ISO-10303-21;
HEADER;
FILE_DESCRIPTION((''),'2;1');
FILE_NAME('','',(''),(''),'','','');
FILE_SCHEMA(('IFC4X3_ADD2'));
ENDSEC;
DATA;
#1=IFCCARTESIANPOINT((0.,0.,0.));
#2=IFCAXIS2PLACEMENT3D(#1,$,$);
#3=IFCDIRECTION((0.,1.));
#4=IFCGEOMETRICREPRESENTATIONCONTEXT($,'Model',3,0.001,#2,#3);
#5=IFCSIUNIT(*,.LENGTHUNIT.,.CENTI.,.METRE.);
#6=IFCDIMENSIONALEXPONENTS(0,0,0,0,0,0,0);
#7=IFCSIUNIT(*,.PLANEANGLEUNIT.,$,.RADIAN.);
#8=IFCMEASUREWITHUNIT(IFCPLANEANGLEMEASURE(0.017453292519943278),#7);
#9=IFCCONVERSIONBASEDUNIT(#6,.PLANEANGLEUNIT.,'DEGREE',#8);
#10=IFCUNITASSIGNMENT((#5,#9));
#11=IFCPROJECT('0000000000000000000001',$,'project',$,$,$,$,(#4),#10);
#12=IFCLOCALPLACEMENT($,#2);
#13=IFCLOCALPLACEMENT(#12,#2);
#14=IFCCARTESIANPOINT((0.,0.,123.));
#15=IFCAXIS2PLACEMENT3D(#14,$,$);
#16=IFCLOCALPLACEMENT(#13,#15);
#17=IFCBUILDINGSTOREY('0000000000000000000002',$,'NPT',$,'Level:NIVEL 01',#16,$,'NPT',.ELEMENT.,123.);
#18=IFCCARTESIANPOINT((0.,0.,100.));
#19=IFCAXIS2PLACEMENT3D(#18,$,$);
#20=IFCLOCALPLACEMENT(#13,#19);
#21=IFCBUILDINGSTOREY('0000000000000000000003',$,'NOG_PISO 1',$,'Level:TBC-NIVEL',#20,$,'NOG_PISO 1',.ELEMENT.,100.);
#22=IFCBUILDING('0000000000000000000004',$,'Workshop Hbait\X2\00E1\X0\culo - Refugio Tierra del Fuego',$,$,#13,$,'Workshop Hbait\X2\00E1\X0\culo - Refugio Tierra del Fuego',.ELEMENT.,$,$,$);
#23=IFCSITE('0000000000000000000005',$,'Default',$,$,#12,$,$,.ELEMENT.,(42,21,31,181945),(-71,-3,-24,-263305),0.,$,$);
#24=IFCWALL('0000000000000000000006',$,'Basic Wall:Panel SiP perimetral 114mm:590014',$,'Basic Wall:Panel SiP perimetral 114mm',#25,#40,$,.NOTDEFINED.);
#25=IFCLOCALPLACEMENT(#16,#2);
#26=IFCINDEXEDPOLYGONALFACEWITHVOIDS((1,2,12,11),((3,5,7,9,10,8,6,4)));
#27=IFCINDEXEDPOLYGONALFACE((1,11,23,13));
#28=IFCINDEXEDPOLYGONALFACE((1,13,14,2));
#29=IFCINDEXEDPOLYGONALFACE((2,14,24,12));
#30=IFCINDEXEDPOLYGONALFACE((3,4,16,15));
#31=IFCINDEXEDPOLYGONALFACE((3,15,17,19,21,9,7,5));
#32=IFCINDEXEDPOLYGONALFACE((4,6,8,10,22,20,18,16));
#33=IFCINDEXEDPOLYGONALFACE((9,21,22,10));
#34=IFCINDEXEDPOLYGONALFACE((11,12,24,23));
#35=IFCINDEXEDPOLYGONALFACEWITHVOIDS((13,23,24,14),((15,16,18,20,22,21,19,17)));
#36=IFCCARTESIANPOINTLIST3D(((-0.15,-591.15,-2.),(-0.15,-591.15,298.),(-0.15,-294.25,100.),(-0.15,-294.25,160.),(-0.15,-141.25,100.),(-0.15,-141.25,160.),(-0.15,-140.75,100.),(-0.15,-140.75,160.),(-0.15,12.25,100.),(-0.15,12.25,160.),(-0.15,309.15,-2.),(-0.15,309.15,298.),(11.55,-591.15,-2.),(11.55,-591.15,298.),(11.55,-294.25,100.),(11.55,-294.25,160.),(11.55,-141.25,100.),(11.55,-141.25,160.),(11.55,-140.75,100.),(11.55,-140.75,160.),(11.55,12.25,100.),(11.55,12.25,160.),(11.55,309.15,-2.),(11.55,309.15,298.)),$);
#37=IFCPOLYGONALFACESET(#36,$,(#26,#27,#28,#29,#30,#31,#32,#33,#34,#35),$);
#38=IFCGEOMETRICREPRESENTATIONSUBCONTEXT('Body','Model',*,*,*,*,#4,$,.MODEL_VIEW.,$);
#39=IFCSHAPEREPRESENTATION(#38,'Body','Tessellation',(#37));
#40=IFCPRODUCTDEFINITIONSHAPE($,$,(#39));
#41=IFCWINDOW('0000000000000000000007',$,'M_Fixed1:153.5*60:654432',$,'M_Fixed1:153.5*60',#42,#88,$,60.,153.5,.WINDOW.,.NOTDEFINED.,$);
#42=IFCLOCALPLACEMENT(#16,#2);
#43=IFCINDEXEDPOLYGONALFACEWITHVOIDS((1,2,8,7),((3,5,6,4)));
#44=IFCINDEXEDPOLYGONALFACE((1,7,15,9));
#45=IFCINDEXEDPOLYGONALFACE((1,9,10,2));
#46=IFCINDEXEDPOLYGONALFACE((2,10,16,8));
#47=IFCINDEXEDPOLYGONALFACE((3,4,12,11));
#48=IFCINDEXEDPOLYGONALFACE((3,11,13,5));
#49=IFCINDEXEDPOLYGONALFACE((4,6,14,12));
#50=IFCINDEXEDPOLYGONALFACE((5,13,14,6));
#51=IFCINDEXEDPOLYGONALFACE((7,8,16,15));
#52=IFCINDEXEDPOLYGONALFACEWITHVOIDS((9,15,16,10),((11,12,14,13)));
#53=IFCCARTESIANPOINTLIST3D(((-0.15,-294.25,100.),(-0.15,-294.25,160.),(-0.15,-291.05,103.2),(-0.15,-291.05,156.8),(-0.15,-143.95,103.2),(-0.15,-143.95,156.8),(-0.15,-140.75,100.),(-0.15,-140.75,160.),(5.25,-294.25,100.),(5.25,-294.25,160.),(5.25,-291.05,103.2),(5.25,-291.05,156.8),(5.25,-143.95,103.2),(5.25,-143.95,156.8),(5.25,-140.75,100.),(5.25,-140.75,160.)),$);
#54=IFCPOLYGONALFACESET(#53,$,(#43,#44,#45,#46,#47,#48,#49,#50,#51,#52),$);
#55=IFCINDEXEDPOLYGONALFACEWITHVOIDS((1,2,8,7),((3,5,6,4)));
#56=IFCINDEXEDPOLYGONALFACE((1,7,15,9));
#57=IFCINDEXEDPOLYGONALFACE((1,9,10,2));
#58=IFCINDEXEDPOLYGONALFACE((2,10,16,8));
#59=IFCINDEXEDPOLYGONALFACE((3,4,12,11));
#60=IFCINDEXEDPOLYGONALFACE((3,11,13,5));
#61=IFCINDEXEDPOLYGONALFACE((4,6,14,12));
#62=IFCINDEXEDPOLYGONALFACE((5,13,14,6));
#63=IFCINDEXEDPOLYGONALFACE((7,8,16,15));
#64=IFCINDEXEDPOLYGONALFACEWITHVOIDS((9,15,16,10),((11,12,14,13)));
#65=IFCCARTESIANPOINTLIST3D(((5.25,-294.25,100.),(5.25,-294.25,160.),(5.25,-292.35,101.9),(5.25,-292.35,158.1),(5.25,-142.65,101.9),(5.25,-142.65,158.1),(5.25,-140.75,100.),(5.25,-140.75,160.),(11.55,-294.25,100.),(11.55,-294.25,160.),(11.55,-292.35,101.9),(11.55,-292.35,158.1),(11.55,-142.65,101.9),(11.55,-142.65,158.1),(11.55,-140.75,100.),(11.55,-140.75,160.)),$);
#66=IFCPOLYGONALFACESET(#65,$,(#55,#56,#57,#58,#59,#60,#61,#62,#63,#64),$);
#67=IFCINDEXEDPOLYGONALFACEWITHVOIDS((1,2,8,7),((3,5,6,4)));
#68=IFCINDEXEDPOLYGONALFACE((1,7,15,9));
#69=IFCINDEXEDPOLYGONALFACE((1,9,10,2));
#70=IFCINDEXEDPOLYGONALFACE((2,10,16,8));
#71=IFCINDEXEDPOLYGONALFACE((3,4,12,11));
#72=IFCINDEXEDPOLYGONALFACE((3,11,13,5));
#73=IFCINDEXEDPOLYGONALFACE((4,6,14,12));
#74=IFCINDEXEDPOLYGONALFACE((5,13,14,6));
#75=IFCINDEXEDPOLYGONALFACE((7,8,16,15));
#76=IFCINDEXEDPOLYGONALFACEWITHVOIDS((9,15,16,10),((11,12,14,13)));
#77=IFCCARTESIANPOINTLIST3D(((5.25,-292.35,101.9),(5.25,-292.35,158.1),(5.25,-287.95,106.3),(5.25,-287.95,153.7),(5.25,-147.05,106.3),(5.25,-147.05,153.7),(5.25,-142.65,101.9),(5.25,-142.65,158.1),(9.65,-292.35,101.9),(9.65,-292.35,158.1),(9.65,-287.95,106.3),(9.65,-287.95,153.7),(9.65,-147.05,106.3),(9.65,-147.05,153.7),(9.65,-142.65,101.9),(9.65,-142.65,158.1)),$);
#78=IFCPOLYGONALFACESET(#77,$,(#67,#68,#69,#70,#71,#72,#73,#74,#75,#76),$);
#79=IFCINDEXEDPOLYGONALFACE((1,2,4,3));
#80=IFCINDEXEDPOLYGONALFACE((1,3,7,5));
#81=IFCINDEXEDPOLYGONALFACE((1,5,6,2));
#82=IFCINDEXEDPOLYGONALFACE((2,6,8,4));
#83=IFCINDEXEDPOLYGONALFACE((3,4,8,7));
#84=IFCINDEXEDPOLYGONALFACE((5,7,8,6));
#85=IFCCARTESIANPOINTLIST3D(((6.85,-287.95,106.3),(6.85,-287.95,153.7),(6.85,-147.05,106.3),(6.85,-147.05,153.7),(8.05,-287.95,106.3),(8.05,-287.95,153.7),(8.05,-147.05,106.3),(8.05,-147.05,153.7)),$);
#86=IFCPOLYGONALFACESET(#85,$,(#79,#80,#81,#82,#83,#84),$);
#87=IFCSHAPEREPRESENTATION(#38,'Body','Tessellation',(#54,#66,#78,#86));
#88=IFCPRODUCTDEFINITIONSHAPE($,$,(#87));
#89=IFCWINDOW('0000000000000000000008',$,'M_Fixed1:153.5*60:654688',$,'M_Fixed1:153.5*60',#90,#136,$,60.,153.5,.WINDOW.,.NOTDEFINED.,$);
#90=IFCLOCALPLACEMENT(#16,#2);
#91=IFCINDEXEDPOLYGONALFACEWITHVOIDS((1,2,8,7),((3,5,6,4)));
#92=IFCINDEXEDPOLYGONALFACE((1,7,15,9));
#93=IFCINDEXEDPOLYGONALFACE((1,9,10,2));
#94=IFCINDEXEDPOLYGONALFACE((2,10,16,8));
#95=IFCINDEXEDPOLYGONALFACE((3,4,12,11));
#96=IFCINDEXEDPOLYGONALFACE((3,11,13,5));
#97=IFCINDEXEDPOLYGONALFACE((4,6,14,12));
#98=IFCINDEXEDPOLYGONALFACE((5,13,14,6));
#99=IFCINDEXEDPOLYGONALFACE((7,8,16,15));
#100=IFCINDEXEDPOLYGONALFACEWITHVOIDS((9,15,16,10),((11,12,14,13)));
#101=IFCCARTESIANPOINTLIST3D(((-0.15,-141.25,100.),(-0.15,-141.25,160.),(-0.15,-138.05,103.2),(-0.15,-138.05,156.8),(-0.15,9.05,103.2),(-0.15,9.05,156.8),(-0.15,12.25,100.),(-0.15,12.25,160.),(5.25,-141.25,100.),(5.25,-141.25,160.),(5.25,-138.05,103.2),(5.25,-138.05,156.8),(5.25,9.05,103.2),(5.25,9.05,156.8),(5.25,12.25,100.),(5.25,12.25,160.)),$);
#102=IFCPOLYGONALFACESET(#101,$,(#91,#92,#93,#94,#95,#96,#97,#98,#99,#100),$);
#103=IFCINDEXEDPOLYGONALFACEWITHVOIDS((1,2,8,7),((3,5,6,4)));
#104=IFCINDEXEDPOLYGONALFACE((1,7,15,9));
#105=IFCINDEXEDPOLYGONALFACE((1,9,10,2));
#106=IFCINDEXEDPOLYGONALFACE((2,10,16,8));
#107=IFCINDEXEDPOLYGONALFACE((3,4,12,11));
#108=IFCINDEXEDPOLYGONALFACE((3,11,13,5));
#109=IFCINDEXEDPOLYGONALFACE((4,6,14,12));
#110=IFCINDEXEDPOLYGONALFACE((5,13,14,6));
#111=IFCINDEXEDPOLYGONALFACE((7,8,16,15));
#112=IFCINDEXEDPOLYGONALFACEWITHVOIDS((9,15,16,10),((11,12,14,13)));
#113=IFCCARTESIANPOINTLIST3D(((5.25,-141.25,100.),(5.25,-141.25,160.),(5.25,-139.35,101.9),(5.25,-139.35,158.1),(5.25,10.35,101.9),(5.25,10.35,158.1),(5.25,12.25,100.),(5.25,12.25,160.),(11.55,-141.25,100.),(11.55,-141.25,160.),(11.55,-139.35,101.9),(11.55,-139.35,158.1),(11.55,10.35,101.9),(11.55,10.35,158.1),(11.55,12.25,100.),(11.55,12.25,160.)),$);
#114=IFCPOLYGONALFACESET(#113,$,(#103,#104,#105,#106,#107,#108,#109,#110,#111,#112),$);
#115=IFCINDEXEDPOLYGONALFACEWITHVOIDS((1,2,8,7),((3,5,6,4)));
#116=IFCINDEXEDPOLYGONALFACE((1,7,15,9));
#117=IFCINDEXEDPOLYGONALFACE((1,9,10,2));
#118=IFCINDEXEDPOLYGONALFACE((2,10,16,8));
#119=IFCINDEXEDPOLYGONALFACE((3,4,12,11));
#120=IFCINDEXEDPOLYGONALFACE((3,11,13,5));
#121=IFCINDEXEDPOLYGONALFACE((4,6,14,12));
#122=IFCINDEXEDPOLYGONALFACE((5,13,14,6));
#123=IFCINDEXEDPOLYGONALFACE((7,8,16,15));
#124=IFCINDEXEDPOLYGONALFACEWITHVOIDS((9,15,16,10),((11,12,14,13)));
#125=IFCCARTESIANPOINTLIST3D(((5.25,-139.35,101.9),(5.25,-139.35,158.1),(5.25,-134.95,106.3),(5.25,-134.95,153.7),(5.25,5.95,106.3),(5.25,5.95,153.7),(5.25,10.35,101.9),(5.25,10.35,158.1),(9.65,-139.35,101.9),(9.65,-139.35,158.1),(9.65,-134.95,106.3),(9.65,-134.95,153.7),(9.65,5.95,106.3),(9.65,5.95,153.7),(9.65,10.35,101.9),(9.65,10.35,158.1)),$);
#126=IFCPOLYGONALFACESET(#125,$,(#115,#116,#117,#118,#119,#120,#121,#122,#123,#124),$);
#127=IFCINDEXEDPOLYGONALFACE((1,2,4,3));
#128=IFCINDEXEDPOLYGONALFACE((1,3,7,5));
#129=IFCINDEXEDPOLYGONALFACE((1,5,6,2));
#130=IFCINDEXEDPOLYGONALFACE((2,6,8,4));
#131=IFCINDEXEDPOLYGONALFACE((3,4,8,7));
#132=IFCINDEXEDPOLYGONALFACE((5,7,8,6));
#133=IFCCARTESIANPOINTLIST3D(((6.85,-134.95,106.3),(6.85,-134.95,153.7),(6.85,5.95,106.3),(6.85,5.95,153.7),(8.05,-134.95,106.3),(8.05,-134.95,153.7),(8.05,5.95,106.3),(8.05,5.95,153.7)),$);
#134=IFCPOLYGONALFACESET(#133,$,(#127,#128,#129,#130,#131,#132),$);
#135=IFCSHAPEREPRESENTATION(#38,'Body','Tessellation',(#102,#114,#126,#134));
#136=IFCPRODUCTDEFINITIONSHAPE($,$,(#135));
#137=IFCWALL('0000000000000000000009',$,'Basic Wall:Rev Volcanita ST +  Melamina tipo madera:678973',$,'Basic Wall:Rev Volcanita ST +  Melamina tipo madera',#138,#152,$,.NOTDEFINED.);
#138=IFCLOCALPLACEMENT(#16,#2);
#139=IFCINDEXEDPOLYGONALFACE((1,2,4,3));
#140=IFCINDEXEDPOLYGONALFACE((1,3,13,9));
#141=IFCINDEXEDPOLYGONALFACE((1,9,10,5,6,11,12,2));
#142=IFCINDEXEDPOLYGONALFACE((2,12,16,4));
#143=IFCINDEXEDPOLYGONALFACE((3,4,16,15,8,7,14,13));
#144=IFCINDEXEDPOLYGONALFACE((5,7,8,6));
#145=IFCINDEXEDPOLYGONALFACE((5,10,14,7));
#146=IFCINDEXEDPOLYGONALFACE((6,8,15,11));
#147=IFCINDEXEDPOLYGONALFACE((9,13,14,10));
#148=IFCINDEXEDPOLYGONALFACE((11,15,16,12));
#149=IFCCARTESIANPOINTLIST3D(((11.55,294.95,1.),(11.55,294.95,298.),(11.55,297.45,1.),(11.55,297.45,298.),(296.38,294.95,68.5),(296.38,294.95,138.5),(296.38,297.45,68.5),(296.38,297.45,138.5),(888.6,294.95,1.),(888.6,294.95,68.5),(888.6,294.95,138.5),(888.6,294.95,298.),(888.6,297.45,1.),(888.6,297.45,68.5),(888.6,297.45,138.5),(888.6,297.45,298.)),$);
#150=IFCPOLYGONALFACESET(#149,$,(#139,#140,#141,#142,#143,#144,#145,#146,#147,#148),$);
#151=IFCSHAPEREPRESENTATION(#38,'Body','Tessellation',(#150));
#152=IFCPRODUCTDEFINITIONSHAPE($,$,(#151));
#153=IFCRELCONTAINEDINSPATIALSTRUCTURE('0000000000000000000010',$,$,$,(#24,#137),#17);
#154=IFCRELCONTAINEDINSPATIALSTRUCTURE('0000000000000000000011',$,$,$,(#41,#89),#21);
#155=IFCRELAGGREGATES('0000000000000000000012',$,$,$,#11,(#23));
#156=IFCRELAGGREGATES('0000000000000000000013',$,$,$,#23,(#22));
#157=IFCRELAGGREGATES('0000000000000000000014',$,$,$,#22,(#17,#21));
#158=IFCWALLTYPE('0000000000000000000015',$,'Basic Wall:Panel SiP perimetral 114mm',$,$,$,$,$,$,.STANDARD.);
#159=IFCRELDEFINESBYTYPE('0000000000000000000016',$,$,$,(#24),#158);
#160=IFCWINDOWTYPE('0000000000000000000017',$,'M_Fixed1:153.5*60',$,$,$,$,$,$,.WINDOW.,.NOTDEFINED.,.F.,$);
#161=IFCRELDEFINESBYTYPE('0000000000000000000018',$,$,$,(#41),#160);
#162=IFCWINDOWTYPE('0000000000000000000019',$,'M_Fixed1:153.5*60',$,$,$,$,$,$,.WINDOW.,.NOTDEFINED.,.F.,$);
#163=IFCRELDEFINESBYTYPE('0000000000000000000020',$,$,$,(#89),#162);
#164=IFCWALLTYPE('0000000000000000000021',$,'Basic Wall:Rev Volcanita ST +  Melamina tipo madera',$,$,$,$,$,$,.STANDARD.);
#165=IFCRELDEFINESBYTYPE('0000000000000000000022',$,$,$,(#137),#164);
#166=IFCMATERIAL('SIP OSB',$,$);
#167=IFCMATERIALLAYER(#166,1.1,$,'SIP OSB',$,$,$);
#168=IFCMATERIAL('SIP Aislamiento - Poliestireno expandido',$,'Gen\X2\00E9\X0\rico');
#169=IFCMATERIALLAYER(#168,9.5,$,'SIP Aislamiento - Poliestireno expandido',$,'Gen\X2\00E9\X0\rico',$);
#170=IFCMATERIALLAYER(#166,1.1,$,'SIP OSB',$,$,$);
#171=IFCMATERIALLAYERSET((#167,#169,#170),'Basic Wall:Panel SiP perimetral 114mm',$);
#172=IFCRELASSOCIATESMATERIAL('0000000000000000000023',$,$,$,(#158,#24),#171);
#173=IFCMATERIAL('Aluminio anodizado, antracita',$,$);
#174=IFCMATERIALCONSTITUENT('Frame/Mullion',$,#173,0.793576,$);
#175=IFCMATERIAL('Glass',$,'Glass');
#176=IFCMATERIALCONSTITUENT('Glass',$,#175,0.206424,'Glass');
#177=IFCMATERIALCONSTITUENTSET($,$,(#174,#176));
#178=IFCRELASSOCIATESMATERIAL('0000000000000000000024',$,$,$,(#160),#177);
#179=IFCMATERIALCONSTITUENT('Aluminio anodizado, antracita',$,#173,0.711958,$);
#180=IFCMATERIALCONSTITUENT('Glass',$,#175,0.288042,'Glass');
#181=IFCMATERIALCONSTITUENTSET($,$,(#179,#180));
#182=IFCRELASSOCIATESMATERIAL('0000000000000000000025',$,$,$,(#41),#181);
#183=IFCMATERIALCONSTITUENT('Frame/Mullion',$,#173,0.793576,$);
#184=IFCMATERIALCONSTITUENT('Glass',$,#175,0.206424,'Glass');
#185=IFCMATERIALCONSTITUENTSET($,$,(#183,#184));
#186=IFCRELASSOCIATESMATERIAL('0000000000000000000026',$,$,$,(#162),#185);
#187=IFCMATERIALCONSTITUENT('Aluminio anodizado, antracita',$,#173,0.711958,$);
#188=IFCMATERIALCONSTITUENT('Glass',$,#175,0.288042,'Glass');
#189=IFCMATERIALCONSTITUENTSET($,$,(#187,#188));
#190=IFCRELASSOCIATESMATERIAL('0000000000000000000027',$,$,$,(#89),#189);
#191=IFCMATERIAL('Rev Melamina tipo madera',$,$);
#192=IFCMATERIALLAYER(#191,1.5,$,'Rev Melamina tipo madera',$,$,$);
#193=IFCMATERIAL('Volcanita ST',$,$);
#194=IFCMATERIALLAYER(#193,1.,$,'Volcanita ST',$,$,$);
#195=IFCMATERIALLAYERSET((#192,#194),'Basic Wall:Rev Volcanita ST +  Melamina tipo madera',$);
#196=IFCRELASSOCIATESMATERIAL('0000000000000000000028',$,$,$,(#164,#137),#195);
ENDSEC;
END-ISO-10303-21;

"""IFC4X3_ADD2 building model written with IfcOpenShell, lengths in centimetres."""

from ifc_helpers import new_model, entity, si_unit, converted_unit, direction, frame, frame_2d, origin, origin_2d_with_axis, place, context, subcontext, project, spatial, polyline, rectangle, outline, extrude, source, transform, mapped, material, layer, layer_set, constituent, constituent_set, type_object, type_shapes, element, fill, save


model = new_model("IFC4X3_ADD2")

# Units and contexts
model_context = context("Model", 3, precision=0.001, world=origin(), true_north=direction((0.0, 1.0)))
body_context = subcontext(model_context, "Body", "Model", "MODEL_VIEW")
ifc_project = project(units=[si_unit("LENGTHUNIT", "METRE", prefix="CENTI"), converted_unit("PLANEANGLEUNIT", "DEGREE", entity("IfcPlaneAngleMeasure", 0.017453292519943278), si_unit("PLANEANGLEUNIT", "RADIAN"), dimensions=[0, 0, 0, 0, 0, 0, 0])], contexts=[model_context])

# Site, building, storey
site_placement = place(None, origin())
site = spatial("IfcSite", under=ifc_project, at=site_placement, Name="Default", CompositionType="ELEMENT", RefLatitude=(42, 21, 31, 181945), RefLongitude=(-71, -3, -24, -263305), RefElevation=0.0)
building_placement = place(site_placement, origin())
building = spatial("IfcBuilding", under=site, at=building_placement, Name="Workshop Hbaitáculo - Refugio Tierra del Fuego", LongName="Workshop Hbaitáculo - Refugio Tierra del Fuego", CompositionType="ELEMENT")
storey_1_placement = place(building_placement, frame((0.0, 0.0, 123.0)))
storey_1 = spatial("IfcBuildingStorey", under=building, at=storey_1_placement, Name="NPT", ObjectType="Level:NIVEL 01", LongName="NPT", CompositionType="ELEMENT", Elevation=123.0)

# Wall, openings
ifc_material_1 = material(Name="SIP OSB")
ifc_layer_1 = layer(ifc_material_1, 1.1, Name="SIP OSB")
ifc_material_2 = material(Name="SIP Aislamiento - Poliestireno expandido", Category="Genérico")
ifc_layer_2 = layer(ifc_material_2, 9.5, Name="SIP Aislamiento - Poliestireno expandido", Category="Genérico")
ifc_layer_3 = layer(ifc_material_1, 1.1, Name="SIP OSB")
ifc_layer_set_1 = layer_set([ifc_layer_1, ifc_layer_2, ifc_layer_3], Name="Basic Wall:Panel SiP perimetral 114mm")
wall_type_1 = type_object("IfcWallType", Name="Basic Wall:Panel SiP perimetral 114mm", PredefinedType="STANDARD", material=ifc_layer_set_1)
wall_1_placement = place(storey_1_placement, frame((5.7, 309.15, -2.0), z_axis=(0.0, 0.0, 1.0), x_axis=(0.0, -1.0, 0.0)))
wall_1 = element("IfcWall", 1, at=wall_1_placement, inside=storey_1, type_object=wall_type_1, material=ifc_layer_set_1, Name="Basic Wall:Panel SiP perimetral 114mm:590014", ObjectType="Basic Wall:Panel SiP perimetral 114mm", PredefinedType="NOTDEFINED", context=body_context, shape_type="SweptSolid", body=[
    extrude(rectangle(XDim=900.3, YDim=11.7, at=frame_2d((450.15, 0.0), x_axis=(-1.0, 0.0))), origin(), (0.0, 0.0, 1.0), 300.0),
])
opening_1_placement = place(wall_1_placement, frame((449.9, -5.85, 102.0)))
opening_1 = element("IfcOpeningElement", 2, at=opening_1_placement, cuts=wall_1, PredefinedType="OPENING", context=body_context, shape_type="SweptSolid", body=[
    extrude(rectangle(XDim=60.0, YDim=153.5, at=frame_2d((30.0, 76.75), x_axis=(1.0, 0.0))), frame((0.0, 0.0, 0.0), z_axis=(0.0, 1.0, 0.0), x_axis=(0.0, 0.0, 1.0)), (0.0, 0.0, 1.0), 11.7),
])
opening_2_placement = place(wall_1_placement, frame((296.9, -5.85, 102.0)))
opening_2 = element("IfcOpeningElement", 3, at=opening_2_placement, cuts=wall_1, PredefinedType="OPENING", context=body_context, shape_type="SweptSolid", body=[
    extrude(rectangle(XDim=60.0, YDim=153.5, at=frame_2d((30.0, 76.75), x_axis=(1.0, 0.0))), frame((0.0, 0.0, 0.0), z_axis=(0.0, 1.0, 0.0), x_axis=(0.0, 0.0, 1.0)), (0.0, 0.0, 1.0), 11.7),
])

# Shared definitions
storey_2_placement = place(building_placement, frame((0.0, 0.0, 100.0)))
storey_2 = spatial("IfcBuildingStorey", under=building, at=storey_2_placement, Name="NOG_PISO 1", ObjectType="Level:TBC-NIVEL", LongName="NOG_PISO 1", CompositionType="ELEMENT", Elevation=100.0)

# Windows
ifc_material_3 = material(Name="Aluminio anodizado, antracita")
ifc_constituent_1 = constituent(ifc_material_3, Name="Aluminio anodizado, antracita", fraction=0.711958)
ifc_material_4 = material(Name="Glass", Category="Glass")
ifc_constituent_2 = constituent(ifc_material_4, Name="Glass", Category="Glass", fraction=0.288042)
ifc_constituent_set_1 = constituent_set(constituents=[ifc_constituent_1, ifc_constituent_2])
ifc_constituent_3 = constituent(ifc_material_3, Name="Frame/Mullion", fraction=0.793576)
ifc_constituent_4 = constituent(ifc_material_4, Name="Glass", Category="Glass", fraction=0.206424)
ifc_constituent_set_2 = constituent_set(constituents=[ifc_constituent_3, ifc_constituent_4])
window_type_1 = type_object("IfcWindowType", Name="M_Fixed1:153.5*60", ParameterTakesPrecedence=False, PartitioningType="NOTDEFINED", PredefinedType="WINDOW", material=ifc_constituent_set_2)
shared_shape_1 = source(origin(), body_context, "Body", "SweptSolid", [
    extrude(outline(polyline([(-76.75, -30.0), (76.75, -30.0), (76.75, 30.0), (-76.75, 30.0), (-76.75, -30.0)]), holes=[polyline([(-73.55, -26.8), (-73.55, 26.8), (73.55, 26.8), (73.55, -26.8), (-73.55, -26.8)])]), frame((76.75, 0.0, 30.0), z_axis=(0.0, 1.0, 0.0), x_axis=(1.0, 0.0, 0.0)), (0.0, 0.0, 1.0), 5.4),
    extrude(outline(polyline([(-76.75, -30.0), (76.75, -30.0), (76.75, 30.0), (-76.75, 30.0), (-76.75, -30.0)]), holes=[polyline([(-74.85, -28.1), (-74.85, 28.1), (74.85, 28.1), (74.85, -28.1), (-74.85, -28.1)])]), frame((76.75, 5.4, 30.0), z_axis=(0.0, 1.0, 0.0), x_axis=(1.0, 0.0, 0.0)), (0.0, 0.0, 1.0), 6.3),
    extrude(outline(polyline([(-74.85, -28.1), (74.85, -28.1), (74.85, 28.1), (-74.85, 28.1), (-74.85, -28.1)]), holes=[polyline([(-70.45, -23.7), (-70.45, 23.7), (70.45, 23.7), (70.45, -23.7), (-70.45, -23.7)])]), frame((76.75, 5.4, 30.0), z_axis=(0.0, 1.0, 0.0), x_axis=(1.0, 0.0, 0.0)), (0.0, 0.0, 1.0), 4.4),
    extrude(rectangle(XDim=1.2, YDim=140.9, at=origin_2d_with_axis()), frame((76.75, 7.6, 6.3), z_axis=(0.0, 0.0, 1.0), x_axis=(0.0, -1.0, 0.0)), (0.0, 0.0, 1.0), 47.4),
])
type_shapes(window_type_1, [shared_shape_1])
window_1_placement = place(opening_1_placement, origin())
window_1 = element("IfcWindow", 4, at=window_1_placement, inside=storey_2, type_object=window_type_1, material=ifc_constituent_set_1, Name="M_Fixed1:153.5*60:654432", ObjectType="M_Fixed1:153.5*60", OverallHeight=60.0, OverallWidth=153.5, PartitioningType="NOTDEFINED", PredefinedType="WINDOW", context=body_context, shape_type="MappedRepresentation", body=[
    mapped(shared_shape_1, transform((0.0, 0.0, 0.0), scale=1.0)),
])
fill(opening_1, window_1)
ifc_constituent_5 = constituent(ifc_material_3, Name="Aluminio anodizado, antracita", fraction=0.711958)
ifc_constituent_6 = constituent(ifc_material_4, Name="Glass", Category="Glass", fraction=0.288042)
ifc_constituent_set_3 = constituent_set(constituents=[ifc_constituent_5, ifc_constituent_6])
ifc_constituent_7 = constituent(ifc_material_3, Name="Frame/Mullion", fraction=0.793576)
ifc_constituent_8 = constituent(ifc_material_4, Name="Glass", Category="Glass", fraction=0.206424)
ifc_constituent_set_4 = constituent_set(constituents=[ifc_constituent_7, ifc_constituent_8])
window_type_2 = type_object("IfcWindowType", Name="M_Fixed1:153.5*60", ParameterTakesPrecedence=False, PartitioningType="NOTDEFINED", PredefinedType="WINDOW", material=ifc_constituent_set_4)
shared_shape_2 = source(origin(), body_context, "Body", "SweptSolid", [
    extrude(outline(polyline([(-76.75, -30.0), (76.75, -30.0), (76.75, 30.0), (-76.75, 30.0), (-76.75, -30.0)]), holes=[polyline([(-73.55, -26.8), (-73.55, 26.8), (73.55, 26.8), (73.55, -26.8), (-73.55, -26.8)])]), frame((76.75, 8.0, 30.0), z_axis=(0.0, -1.0, 0.0), x_axis=(-1.0, 0.0, 0.0)), (0.0, 0.0, 1.0), 5.4),
    extrude(outline(polyline([(-76.75, -30.0), (76.75, -30.0), (76.75, 30.0), (-76.75, 30.0), (-76.75, -30.0)]), holes=[polyline([(-74.85, -28.1), (-74.85, 28.1), (74.85, 28.1), (74.85, -28.1), (-74.85, -28.1)])]), frame((76.75, 14.3, 30.0), z_axis=(0.0, -1.0, 0.0), x_axis=(-1.0, 0.0, 0.0)), (0.0, 0.0, 1.0), 6.3),
    extrude(outline(polyline([(-74.85, -28.1), (74.85, -28.1), (74.85, 28.1), (-74.85, 28.1), (-74.85, -28.1)]), holes=[polyline([(-70.45, -23.7), (-70.45, 23.7), (70.45, 23.7), (70.45, -23.7), (-70.45, -23.7)])]), frame((76.75, 12.4, 30.0), z_axis=(0.0, -1.0, 0.0), x_axis=(-1.0, 0.0, 0.0)), (0.0, 0.0, 1.0), 4.4),
    extrude(rectangle(XDim=140.9, YDim=1.2, at=origin_2d_with_axis()), frame((76.75, 10.2, 6.3), z_axis=(0.0, 0.0, 1.0), x_axis=(-1.0, 0.0, 0.0)), (0.0, 0.0, 1.0), 47.4),
])
type_shapes(window_type_2, [shared_shape_2])
window_2_placement = place(opening_2_placement, frame((0.0, -2.6, 0.0)))
window_2 = element("IfcWindow", 5, at=window_2_placement, inside=storey_2, type_object=window_type_2, material=ifc_constituent_set_3, Name="M_Fixed1:153.5*60:654688", ObjectType="M_Fixed1:153.5*60", OverallHeight=60.0, OverallWidth=153.5, PartitioningType="NOTDEFINED", PredefinedType="WINDOW", context=body_context, shape_type="MappedRepresentation", body=[
    mapped(shared_shape_2, transform((0.0, 0.0, 0.0), scale=1.0)),
])
fill(opening_2, window_2)

# Wall, opening
ifc_material_5 = material(Name="Rev Melamina tipo madera")
ifc_layer_4 = layer(ifc_material_5, 1.5, Name="Rev Melamina tipo madera")
ifc_material_6 = material(Name="Volcanita ST")
ifc_layer_5 = layer(ifc_material_6, 1.0, Name="Volcanita ST")
ifc_layer_set_2 = layer_set([ifc_layer_4, ifc_layer_5], Name="Basic Wall:Rev Volcanita ST +  Melamina tipo madera")
wall_type_2 = type_object("IfcWallType", Name="Basic Wall:Rev Volcanita ST +  Melamina tipo madera", PredefinedType="STANDARD", material=ifc_layer_set_2)
wall_2_placement = place(storey_1_placement, frame((11.55, 296.2, 1.0)))
wall_2 = element("IfcWall", 6, at=wall_2_placement, inside=storey_1, type_object=wall_type_2, material=ifc_layer_set_2, Name="Basic Wall:Rev Volcanita ST +  Melamina tipo madera:678973", ObjectType="Basic Wall:Rev Volcanita ST +  Melamina tipo madera", PredefinedType="NOTDEFINED", context=body_context, shape_type="SweptSolid", body=[
    extrude(rectangle(XDim=877.05, YDim=2.5, at=frame_2d((438.53, 0.0), x_axis=(-1.0, 0.0))), origin(), (0.0, 0.0, 1.0), 297.0),
])
opening_3_placement = place(wall_2_placement, origin())
element("IfcOpeningElement", 7, at=opening_3_placement, cuts=wall_2, PredefinedType="OPENING", context=body_context, shape_type="SweptSolid", body=[
    extrude(rectangle(XDim=70.0, YDim=592.22, at=frame_2d((0.0, 0.0), x_axis=(1.0, 0.0))), frame((580.94, 1.25, 102.5), z_axis=(0.0, -1.0, 0.0), x_axis=(0.0, 0.0, 1.0)), (0.0, 0.0, 1.0), 2.5),
])

save(model, "model.ifc")
